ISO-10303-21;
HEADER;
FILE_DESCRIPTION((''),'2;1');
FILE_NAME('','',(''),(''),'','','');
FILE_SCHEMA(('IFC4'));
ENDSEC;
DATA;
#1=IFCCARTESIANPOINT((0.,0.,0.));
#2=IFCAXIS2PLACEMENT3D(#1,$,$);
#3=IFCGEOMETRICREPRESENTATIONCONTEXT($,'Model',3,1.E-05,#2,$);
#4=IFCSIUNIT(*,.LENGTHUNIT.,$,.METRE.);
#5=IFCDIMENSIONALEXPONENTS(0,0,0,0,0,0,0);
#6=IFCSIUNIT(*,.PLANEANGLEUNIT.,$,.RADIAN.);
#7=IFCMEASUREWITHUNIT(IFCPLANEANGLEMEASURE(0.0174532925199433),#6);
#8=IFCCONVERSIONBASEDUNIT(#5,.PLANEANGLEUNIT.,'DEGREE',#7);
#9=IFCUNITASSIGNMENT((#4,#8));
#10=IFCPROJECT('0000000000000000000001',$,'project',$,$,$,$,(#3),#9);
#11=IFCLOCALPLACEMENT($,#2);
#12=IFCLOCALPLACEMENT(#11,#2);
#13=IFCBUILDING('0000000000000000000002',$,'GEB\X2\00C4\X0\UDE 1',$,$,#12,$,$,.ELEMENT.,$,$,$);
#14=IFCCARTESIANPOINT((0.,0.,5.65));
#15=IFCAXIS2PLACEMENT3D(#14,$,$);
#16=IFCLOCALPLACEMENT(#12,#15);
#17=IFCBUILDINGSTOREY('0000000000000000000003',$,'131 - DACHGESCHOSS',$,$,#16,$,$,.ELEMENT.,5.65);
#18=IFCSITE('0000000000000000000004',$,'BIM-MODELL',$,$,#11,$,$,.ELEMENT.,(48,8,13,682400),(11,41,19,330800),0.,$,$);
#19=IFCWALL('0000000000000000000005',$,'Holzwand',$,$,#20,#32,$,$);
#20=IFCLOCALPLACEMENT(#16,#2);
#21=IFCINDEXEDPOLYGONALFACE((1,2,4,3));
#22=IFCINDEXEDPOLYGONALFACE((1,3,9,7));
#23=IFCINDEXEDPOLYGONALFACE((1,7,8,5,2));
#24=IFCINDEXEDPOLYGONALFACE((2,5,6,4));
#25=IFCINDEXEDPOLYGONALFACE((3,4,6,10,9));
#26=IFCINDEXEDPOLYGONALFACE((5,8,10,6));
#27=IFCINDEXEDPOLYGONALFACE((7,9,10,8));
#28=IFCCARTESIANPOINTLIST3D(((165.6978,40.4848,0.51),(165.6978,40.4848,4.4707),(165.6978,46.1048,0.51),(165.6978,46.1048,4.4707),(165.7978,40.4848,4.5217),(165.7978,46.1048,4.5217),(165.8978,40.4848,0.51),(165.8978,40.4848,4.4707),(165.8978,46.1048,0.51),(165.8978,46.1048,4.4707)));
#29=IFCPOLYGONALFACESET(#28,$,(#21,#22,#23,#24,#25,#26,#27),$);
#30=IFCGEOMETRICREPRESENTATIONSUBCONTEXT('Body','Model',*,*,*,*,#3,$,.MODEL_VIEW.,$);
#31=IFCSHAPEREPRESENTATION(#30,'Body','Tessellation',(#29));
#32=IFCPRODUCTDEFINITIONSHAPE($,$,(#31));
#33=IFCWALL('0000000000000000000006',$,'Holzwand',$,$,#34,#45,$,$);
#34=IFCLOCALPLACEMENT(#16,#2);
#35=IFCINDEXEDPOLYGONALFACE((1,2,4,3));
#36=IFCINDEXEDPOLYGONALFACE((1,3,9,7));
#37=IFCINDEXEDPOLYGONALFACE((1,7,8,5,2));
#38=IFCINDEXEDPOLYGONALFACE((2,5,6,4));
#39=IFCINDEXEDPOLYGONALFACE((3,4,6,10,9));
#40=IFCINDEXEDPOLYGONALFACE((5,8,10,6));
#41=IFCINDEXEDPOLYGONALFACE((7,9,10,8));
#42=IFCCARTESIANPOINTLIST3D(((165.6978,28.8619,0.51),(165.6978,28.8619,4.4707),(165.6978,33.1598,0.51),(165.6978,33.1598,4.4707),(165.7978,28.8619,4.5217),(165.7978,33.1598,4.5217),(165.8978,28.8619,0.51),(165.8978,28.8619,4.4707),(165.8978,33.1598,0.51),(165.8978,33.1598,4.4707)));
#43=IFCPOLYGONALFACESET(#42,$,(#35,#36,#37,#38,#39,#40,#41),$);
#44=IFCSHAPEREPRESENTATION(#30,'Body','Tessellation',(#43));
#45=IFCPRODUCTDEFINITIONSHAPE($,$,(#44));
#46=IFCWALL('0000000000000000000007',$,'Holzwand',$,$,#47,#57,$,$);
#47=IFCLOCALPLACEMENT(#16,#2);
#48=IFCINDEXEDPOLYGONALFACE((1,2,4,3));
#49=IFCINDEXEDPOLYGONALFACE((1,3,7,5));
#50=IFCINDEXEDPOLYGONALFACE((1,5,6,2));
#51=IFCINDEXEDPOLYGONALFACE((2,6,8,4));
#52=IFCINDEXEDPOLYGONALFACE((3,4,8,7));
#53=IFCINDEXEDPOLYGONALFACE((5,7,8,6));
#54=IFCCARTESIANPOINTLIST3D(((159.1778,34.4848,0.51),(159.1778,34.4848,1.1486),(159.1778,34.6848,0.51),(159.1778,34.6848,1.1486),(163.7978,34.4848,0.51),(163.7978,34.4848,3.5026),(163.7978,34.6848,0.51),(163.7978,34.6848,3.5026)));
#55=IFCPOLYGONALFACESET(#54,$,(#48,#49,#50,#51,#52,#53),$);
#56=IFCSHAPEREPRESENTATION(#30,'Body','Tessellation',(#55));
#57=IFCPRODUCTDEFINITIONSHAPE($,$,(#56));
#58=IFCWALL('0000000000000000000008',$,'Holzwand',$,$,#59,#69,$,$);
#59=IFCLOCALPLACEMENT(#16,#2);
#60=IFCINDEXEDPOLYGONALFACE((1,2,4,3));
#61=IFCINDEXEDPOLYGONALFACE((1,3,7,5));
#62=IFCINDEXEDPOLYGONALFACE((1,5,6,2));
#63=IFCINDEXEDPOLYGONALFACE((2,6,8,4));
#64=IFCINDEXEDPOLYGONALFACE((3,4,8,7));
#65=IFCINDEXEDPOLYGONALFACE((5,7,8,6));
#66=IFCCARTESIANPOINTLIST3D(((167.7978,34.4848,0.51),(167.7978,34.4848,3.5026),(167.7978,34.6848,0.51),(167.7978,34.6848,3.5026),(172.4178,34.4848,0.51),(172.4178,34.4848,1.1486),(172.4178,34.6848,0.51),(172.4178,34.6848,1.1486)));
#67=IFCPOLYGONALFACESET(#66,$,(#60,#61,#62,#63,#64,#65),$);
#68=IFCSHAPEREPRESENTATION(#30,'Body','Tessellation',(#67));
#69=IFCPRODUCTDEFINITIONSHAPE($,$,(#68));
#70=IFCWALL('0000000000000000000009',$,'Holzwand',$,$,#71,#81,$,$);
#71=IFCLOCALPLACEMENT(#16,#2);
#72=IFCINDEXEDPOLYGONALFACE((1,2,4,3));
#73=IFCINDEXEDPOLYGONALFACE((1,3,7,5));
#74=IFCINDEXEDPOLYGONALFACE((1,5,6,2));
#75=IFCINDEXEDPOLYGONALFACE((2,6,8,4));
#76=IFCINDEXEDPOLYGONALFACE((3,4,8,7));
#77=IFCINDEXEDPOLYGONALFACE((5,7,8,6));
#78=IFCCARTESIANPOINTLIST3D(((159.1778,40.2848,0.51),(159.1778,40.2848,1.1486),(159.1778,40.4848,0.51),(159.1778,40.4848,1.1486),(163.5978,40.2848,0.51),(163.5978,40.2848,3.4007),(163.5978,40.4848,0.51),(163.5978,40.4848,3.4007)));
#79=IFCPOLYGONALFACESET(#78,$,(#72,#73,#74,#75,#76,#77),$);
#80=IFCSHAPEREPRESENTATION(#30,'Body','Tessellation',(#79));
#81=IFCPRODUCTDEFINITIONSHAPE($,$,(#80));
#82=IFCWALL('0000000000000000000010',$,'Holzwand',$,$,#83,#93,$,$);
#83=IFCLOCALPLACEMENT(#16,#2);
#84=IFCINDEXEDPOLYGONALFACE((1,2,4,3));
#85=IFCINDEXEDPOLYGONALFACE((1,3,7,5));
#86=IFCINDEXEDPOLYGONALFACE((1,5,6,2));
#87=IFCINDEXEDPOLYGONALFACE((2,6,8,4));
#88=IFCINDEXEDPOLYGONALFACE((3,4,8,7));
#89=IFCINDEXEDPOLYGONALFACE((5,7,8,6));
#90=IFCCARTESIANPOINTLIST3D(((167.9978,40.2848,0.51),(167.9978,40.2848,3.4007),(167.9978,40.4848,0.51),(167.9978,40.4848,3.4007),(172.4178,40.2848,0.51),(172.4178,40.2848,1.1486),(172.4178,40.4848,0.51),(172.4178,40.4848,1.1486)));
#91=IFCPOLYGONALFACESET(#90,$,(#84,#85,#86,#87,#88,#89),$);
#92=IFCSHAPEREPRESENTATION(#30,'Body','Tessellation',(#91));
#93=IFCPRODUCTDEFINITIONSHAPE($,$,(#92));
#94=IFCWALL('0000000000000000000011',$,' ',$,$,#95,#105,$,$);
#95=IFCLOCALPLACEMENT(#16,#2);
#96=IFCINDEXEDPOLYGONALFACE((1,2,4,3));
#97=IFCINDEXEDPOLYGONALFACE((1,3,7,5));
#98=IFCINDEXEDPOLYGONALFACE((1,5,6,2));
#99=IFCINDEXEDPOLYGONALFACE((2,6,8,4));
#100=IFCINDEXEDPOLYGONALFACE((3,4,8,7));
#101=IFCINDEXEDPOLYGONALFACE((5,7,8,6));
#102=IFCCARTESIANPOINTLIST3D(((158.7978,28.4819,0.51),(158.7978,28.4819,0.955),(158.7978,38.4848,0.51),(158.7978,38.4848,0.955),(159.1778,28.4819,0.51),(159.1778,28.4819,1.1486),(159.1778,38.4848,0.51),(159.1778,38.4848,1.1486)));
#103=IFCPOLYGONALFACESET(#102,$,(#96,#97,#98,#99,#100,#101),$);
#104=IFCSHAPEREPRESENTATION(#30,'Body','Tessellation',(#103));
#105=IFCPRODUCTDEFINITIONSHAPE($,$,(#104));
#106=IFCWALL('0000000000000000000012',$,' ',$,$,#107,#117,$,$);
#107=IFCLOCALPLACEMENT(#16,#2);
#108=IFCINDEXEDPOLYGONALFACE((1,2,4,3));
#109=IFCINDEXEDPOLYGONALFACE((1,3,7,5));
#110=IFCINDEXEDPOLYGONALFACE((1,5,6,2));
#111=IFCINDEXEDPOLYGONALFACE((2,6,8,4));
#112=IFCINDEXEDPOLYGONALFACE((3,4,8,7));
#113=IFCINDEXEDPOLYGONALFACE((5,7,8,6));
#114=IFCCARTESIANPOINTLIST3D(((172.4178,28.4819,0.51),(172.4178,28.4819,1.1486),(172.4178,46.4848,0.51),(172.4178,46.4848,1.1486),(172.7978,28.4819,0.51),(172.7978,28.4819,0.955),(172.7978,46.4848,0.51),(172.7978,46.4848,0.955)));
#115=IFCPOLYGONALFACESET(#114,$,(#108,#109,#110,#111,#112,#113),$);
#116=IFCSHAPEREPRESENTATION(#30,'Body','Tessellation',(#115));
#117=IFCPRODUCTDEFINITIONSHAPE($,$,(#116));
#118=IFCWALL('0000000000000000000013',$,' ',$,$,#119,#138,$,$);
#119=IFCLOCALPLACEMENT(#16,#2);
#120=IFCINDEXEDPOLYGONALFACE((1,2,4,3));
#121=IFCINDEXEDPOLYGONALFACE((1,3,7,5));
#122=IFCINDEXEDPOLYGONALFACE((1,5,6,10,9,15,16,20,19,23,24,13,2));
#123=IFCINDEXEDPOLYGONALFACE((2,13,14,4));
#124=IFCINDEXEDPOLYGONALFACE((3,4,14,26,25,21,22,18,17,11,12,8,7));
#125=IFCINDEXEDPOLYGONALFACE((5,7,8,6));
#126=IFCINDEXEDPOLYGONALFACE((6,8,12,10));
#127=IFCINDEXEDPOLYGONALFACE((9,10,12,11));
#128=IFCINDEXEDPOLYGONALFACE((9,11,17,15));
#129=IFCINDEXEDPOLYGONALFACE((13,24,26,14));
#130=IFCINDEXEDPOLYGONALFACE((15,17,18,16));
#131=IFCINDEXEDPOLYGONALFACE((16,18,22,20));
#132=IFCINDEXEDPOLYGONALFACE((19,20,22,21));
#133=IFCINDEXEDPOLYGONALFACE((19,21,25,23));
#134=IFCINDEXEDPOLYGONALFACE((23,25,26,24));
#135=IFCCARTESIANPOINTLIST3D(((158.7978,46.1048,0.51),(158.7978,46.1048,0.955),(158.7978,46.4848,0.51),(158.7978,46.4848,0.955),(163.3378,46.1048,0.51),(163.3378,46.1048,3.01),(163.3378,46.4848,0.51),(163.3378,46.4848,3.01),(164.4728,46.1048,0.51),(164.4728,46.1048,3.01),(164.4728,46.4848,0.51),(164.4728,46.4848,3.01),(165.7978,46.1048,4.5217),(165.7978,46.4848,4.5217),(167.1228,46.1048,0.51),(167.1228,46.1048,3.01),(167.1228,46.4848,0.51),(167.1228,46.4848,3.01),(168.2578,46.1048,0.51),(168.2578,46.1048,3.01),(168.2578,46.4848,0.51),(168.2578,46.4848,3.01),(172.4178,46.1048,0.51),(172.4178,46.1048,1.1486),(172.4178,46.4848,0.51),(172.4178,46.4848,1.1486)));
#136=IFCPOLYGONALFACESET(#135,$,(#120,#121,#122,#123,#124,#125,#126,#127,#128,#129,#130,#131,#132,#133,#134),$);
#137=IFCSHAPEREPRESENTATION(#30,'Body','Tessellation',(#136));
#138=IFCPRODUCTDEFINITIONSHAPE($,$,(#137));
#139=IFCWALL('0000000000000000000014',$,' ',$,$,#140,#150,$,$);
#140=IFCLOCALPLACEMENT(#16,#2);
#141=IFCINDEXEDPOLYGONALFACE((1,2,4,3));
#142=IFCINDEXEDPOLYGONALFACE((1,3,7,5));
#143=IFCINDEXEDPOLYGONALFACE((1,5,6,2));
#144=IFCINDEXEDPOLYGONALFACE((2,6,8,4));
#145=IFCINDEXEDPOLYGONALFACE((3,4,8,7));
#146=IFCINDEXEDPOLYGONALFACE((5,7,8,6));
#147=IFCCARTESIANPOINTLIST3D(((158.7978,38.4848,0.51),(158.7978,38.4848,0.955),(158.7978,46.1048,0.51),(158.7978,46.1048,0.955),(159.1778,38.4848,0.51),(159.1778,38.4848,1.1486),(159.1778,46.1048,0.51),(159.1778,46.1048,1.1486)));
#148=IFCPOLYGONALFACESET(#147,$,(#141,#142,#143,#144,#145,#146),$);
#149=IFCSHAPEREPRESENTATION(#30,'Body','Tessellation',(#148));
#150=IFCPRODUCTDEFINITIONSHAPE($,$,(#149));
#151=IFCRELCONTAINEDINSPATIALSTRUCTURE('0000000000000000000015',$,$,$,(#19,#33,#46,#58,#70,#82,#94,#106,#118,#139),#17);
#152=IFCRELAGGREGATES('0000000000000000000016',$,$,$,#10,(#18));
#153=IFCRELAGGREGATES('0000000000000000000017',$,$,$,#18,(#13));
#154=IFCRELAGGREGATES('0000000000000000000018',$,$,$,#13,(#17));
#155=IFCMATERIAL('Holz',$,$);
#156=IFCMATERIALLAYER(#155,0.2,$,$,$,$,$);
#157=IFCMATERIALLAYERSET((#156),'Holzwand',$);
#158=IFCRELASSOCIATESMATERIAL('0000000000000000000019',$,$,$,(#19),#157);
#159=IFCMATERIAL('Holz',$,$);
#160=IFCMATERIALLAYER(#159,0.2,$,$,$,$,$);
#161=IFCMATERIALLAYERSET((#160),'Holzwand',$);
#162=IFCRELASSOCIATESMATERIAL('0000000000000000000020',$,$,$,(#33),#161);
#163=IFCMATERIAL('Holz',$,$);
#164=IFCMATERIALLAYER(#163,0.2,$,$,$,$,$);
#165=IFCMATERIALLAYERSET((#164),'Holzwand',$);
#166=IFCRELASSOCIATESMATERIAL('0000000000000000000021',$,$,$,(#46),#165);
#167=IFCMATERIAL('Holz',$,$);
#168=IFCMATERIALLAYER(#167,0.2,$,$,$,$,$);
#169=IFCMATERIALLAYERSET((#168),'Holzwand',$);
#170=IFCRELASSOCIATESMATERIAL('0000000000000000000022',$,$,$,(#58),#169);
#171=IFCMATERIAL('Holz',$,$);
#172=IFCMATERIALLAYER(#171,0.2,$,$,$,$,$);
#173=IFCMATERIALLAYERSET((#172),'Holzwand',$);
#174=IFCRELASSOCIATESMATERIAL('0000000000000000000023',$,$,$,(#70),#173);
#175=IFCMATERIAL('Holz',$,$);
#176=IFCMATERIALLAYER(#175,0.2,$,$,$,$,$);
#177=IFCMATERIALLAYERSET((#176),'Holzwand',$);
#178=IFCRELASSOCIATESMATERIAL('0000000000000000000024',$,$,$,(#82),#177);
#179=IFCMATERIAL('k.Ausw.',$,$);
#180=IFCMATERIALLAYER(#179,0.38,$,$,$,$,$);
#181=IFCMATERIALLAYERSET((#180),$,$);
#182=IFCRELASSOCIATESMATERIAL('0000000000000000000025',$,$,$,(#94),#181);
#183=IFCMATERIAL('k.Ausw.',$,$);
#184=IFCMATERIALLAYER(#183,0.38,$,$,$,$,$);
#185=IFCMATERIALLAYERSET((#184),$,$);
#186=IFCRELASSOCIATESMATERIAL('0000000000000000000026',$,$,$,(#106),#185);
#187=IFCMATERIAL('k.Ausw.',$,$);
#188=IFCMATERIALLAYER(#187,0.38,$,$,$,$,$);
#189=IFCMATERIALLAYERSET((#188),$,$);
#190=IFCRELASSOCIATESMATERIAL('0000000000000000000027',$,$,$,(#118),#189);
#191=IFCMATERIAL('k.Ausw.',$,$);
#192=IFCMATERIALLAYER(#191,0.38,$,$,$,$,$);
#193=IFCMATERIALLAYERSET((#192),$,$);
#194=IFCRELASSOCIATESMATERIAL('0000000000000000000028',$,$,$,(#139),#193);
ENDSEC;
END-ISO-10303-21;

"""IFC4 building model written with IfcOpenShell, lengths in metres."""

from ifc_helpers import new_model, entity, si_unit, converted_unit, frame, frame_2d, origin, origin_with_axes, place, context, subcontext, project, spatial, polyline, rectangle, outline, extrude, clip, halfspace, bounded_halfspace, material, layer, layer_set, layer_usage, element, save


model = new_model("IFC4")

# Units and contexts
model_context = context("Model", 3, precision=1e-05, world=origin())
body_context = subcontext(model_context, "Body", "Model", "MODEL_VIEW")
ifc_project = project(units=[si_unit("LENGTHUNIT", "METRE"), converted_unit("PLANEANGLEUNIT", "DEGREE", entity("IfcPlaneAngleMeasure", 0.0174532925199433), si_unit("PLANEANGLEUNIT", "RADIAN"), dimensions=[0, 0, 0, 0, 0, 0, 0])], contexts=[model_context])

# Site, building, storey
site_placement = place(None, origin())
site = spatial("IfcSite", under=ifc_project, at=site_placement, Name="BIM-MODELL", CompositionType="ELEMENT", RefLatitude=(48, 8, 13, 682400), RefLongitude=(11, 41, 19, 330800), RefElevation=0.0)
building_placement = place(site_placement, origin())
building = spatial("IfcBuilding", under=site, at=building_placement, Name="GEBÄUDE 1", CompositionType="ELEMENT")
storey_placement = place(building_placement, frame((0.0, 0.0, 5.65)))
storey = spatial("IfcBuildingStorey", under=building, at=storey_placement, Name="131 - DACHGESCHOSS", CompositionType="ELEMENT", Elevation=5.65)

# Walls
ifc_material_1 = material(Name="Holz")
ifc_layer_1 = layer(ifc_material_1, 0.2)
ifc_layer_set_1 = layer_set([ifc_layer_1], Name="Holzwand")
ifc_layer_usage_1 = layer_usage(ifc_layer_set_1, "AXIS2", "POSITIVE", 0.0)
wall_1_placement = place(storey_placement, frame((165.6978, 46.1048, 0.51), z_axis=(0.0, 0.0, 1.0), x_axis=(0.0, -1.0, 0.0)))
element("IfcWall", 1, at=wall_1_placement, inside=storey, material=ifc_layer_usage_1, Name="Holzwand", context=body_context, shape_type="Clipping", body=[
    clip(clip(extrude(rectangle(XDim=5.62, YDim=0.2, at=frame_2d((2.81, 0.1), x_axis=(1.0, 0.0))), origin_with_axes(), (0.0, 0.0, 1.0), 4.0117), bounded_halfspace(frame((2.81, 0.05, 3.9862), z_axis=(0.0, 0.45399, -0.891007), x_axis=(0.0, 0.891007, 0.45399)), True, origin_with_axes(), polyline([(5.62, 0.0), (5.62, 0.1), (0.0, 0.1), (0.0, 0.0), (5.62, 0.0)]))), bounded_halfspace(frame((2.81, 0.15, 3.9862), z_axis=(0.0, -0.45399, -0.891007), x_axis=(0.0, -0.891007, 0.45399)), True, origin_with_axes(), polyline([(0.0, 0.2), (0.0, 0.1), (5.62, 0.1), (5.62, 0.2), (0.0, 0.2)]))),
])
ifc_material_2 = material(Name="Holz")
ifc_layer_2 = layer(ifc_material_2, 0.2)
ifc_layer_set_2 = layer_set([ifc_layer_2], Name="Holzwand")
ifc_layer_usage_2 = layer_usage(ifc_layer_set_2, "AXIS2", "POSITIVE", 0.0)
wall_2_placement = place(storey_placement, frame((165.6978, 33.1598, 0.51), z_axis=(0.0, 0.0, 1.0), x_axis=(0.0, -1.0, 0.0)))
element("IfcWall", 2, at=wall_2_placement, inside=storey, material=ifc_layer_usage_2, Name="Holzwand", context=body_context, shape_type="Clipping", body=[
    clip(clip(extrude(rectangle(XDim=4.2979, YDim=0.2, at=frame_2d((2.1489, 0.1), x_axis=(1.0, 0.0))), origin_with_axes(), (0.0, 0.0, 1.0), 4.0117), bounded_halfspace(frame((2.1489, 0.05, 3.9862), z_axis=(0.0, 0.45399, -0.891007), x_axis=(0.0, 0.891007, 0.45399)), True, origin_with_axes(), polyline([(4.2979, 0.0), (4.2979, 0.1), (0.0, 0.1), (0.0, 0.0), (4.2979, 0.0)]))), bounded_halfspace(frame((2.1489, 0.15, 3.9862), z_axis=(0.0, -0.45399, -0.891007), x_axis=(0.0, -0.891007, 0.45399)), True, origin_with_axes(), polyline([(0.0, 0.2), (0.0, 0.1), (4.2979, 0.1), (4.2979, 0.2), (0.0, 0.2)]))),
])
ifc_material_3 = material(Name="Holz")
ifc_layer_3 = layer(ifc_material_3, 0.2)
ifc_layer_set_3 = layer_set([ifc_layer_3], Name="Holzwand")
ifc_layer_usage_3 = layer_usage(ifc_layer_set_3, "AXIS2", "POSITIVE", 0.0)
wall_3_placement = place(storey_placement, frame((159.1778, 34.4848, 0.51)))
element("IfcWall", 3, at=wall_3_placement, inside=storey, material=ifc_layer_usage_3, Name="Holzwand", context=body_context, shape_type="Clipping", body=[
    clip(extrude(rectangle(XDim=4.62, YDim=0.2, at=frame_2d((2.31, 0.1), x_axis=(1.0, 0.0))), origin_with_axes(), (0.0, 0.0, 1.0), 2.9926), halfspace(frame((2.31, 0.1, 1.8156), z_axis=(0.45399, 0.0, -0.891007), x_axis=(0.891007, 0.0, 0.45399)), True)),
])
ifc_material_4 = material(Name="Holz")
ifc_layer_4 = layer(ifc_material_4, 0.2)
ifc_layer_set_4 = layer_set([ifc_layer_4], Name="Holzwand")
ifc_layer_usage_4 = layer_usage(ifc_layer_set_4, "AXIS2", "POSITIVE", 0.0)
wall_4_placement = place(storey_placement, frame((167.7978, 34.4848, 0.51)))
element("IfcWall", 4, at=wall_4_placement, inside=storey, material=ifc_layer_usage_4, Name="Holzwand", context=body_context, shape_type="Clipping", body=[
    clip(extrude(rectangle(XDim=4.62, YDim=0.2, at=frame_2d((2.31, 0.1), x_axis=(1.0, 0.0))), origin_with_axes(), (0.0, 0.0, 1.0), 2.9926), halfspace(frame((2.31, 0.1, 1.8156), z_axis=(-0.45399, 0.0, -0.891007), x_axis=(0.891007, 0.0, -0.45399)), True)),
])
ifc_material_5 = material(Name="Holz")
ifc_layer_5 = layer(ifc_material_5, 0.2)
ifc_layer_set_5 = layer_set([ifc_layer_5], Name="Holzwand")
ifc_layer_usage_5 = layer_usage(ifc_layer_set_5, "AXIS2", "POSITIVE", 0.0)
wall_5_placement = place(storey_placement, frame((163.5978, 40.4848, 0.51), z_axis=(0.0, 0.0, 1.0), x_axis=(-1.0, 0.0, 0.0)))
element("IfcWall", 5, at=wall_5_placement, inside=storey, material=ifc_layer_usage_5, Name="Holzwand", context=body_context, shape_type="Clipping", body=[
    clip(extrude(rectangle(XDim=4.42, YDim=0.2, at=frame_2d((2.21, 0.1), x_axis=(1.0, 0.0))), origin_with_axes(), (0.0, 0.0, 1.0), 2.8907), halfspace(frame((2.21, 0.1, 1.7647), z_axis=(-0.45399, 0.0, -0.891007), x_axis=(0.891007, 0.0, -0.45399)), True)),
])
ifc_material_6 = material(Name="Holz")
ifc_layer_6 = layer(ifc_material_6, 0.2)
ifc_layer_set_6 = layer_set([ifc_layer_6], Name="Holzwand")
ifc_layer_usage_6 = layer_usage(ifc_layer_set_6, "AXIS2", "POSITIVE", 0.0)
wall_6_placement = place(storey_placement, frame((172.4178, 40.4848, 0.51), z_axis=(0.0, 0.0, 1.0), x_axis=(-1.0, 0.0, 0.0)))
element("IfcWall", 6, at=wall_6_placement, inside=storey, material=ifc_layer_usage_6, Name="Holzwand", context=body_context, shape_type="Clipping", body=[
    clip(extrude(rectangle(XDim=4.42, YDim=0.2, at=frame_2d((2.21, 0.1), x_axis=(1.0, 0.0))), origin_with_axes(), (0.0, 0.0, 1.0), 2.8907), halfspace(frame((2.21, 0.1, 1.7647), z_axis=(0.45399, 0.0, -0.891007), x_axis=(0.891007, 0.0, 0.45399)), True)),
])
ifc_material_7 = material(Name="k.Ausw.")
ifc_layer_7 = layer(ifc_material_7, 0.38)
ifc_layer_set_7 = layer_set([ifc_layer_7])
ifc_layer_usage_7 = layer_usage(ifc_layer_set_7, "AXIS2", "POSITIVE", 0.0)
wall_7_placement = place(storey_placement, frame((158.7978, 38.4848, 0.51), z_axis=(0.0, 0.0, 1.0), x_axis=(0.0, -1.0, 0.0)))
element("IfcWall", 7, at=wall_7_placement, inside=storey, material=ifc_layer_usage_7, Name=" ", context=body_context, shape_type="Clipping", body=[
    clip(extrude(rectangle(XDim=10.0029, YDim=0.38, at=frame_2d((5.0014, 0.19), x_axis=(1.0, 0.0))), origin_with_axes(), (0.0, 0.0, 1.0), 0.6386), halfspace(frame((5.0014, 0.19, 0.5418), z_axis=(0.0, 0.45399, -0.891007), x_axis=(0.0, -0.891007, -0.45399)), True)),
])
ifc_material_8 = material(Name="k.Ausw.")
ifc_layer_8 = layer(ifc_material_8, 0.38)
ifc_layer_set_8 = layer_set([ifc_layer_8])
ifc_layer_usage_8 = layer_usage(ifc_layer_set_8, "AXIS2", "POSITIVE", 0.0)
wall_8_placement = place(storey_placement, frame((172.7978, 28.4819, 0.51), z_axis=(0.0, 0.0, 1.0), x_axis=(0.0, 1.0, 0.0)))
element("IfcWall", 8, at=wall_8_placement, inside=storey, material=ifc_layer_usage_8, Name=" ", context=body_context, shape_type="Clipping", body=[
    clip(extrude(rectangle(XDim=18.0029, YDim=0.38, at=frame_2d((9.0014, 0.19), x_axis=(1.0, 0.0))), origin_with_axes(), (0.0, 0.0, 1.0), 0.6386), halfspace(frame((9.0014, 0.19, 0.5418), z_axis=(0.0, 0.45399, -0.891007), x_axis=(0.0, -0.891007, -0.45399)), True)),
])

# Wall, openings
ifc_material_9 = material(Name="k.Ausw.")
ifc_layer_9 = layer(ifc_material_9, 0.38)
ifc_layer_set_9 = layer_set([ifc_layer_9])
ifc_layer_usage_9 = layer_usage(ifc_layer_set_9, "AXIS2", "POSITIVE", 0.0)
wall_9_placement = place(storey_placement, frame((172.4178, 46.4848, 0.51), z_axis=(0.0, 0.0, 1.0), x_axis=(-1.0, 0.0, 0.0)))
wall_9 = element("IfcWall", 9, at=wall_9_placement, inside=storey, material=ifc_layer_usage_9, Name=" ", context=body_context, shape_type="Clipping", body=[
    clip(clip(extrude(rectangle(XDim=13.62, YDim=0.38, at=frame_2d((6.81, 0.19), x_axis=(1.0, 0.0))), origin_with_axes(), (0.0, 0.0, 1.0), 4.0117), bounded_halfspace(frame((10.12, 0.19, 2.2283), z_axis=(-0.45399, 0.0, -0.891007), x_axis=(0.0, -1.0, 0.0)), True, origin_with_axes(), polyline([(6.62, 0.38), (6.62, 0.0), (13.62, 0.0), (13.62, 0.38), (6.62, 0.38)]))), bounded_halfspace(frame((3.31, 0.19, 2.3251), z_axis=(0.45399, 0.0, -0.891007), x_axis=(0.0, -1.0, 0.0)), True, origin_with_axes(), polyline([(0.0, 0.38), (0.0, 0.0), (6.62, 0.0), (6.62, 0.38), (0.0, 0.38)]))),
])
opening_1_placement = place(wall_9_placement, frame((5.295, 0.38, 0.0), z_axis=(0.0, -1.0, 0.0), x_axis=(0.0, 0.0, 1.0)))
element("IfcOpeningElement", 10, at=opening_1_placement, cuts=wall_9, ObjectType="Opening", context=body_context, shape_type="SweptSolid", body=[
    extrude(outline(polyline([(0.0, 1.135), (2.5, 1.135), (2.5, 0.0), (0.0, 0.0), (0.0, 1.135)])), origin_with_axes(), (0.0, 0.0, 1.0), 0.38),
])
opening_2_placement = place(wall_9_placement, frame((9.08, 0.38, 0.0), z_axis=(0.0, -1.0, 0.0), x_axis=(0.0, 0.0, 1.0)))
element("IfcOpeningElement", 11, at=opening_2_placement, cuts=wall_9, ObjectType="Opening", context=body_context, shape_type="SweptSolid", body=[
    extrude(outline(polyline([(0.0, 1.135), (2.5, 1.135), (2.5, 0.0), (0.0, 0.0), (0.0, 1.135)])), origin_with_axes(), (0.0, 0.0, 1.0), 0.38),
])

# Wall
ifc_material_10 = material(Name="k.Ausw.")
ifc_layer_10 = layer(ifc_material_10, 0.38)
ifc_layer_set_10 = layer_set([ifc_layer_10])
ifc_layer_usage_10 = layer_usage(ifc_layer_set_10, "AXIS2", "POSITIVE", 0.0)
wall_10_placement = place(storey_placement, frame((158.7978, 46.1048, 0.51), z_axis=(0.0, 0.0, 1.0), x_axis=(0.0, -1.0, 0.0)))
element("IfcWall", 12, at=wall_10_placement, inside=storey, material=ifc_layer_usage_10, Name=" ", context=body_context, shape_type="Clipping", body=[
    clip(extrude(rectangle(XDim=7.62, YDim=0.38, at=frame_2d((3.81, 0.19), x_axis=(1.0, 0.0))), origin_with_axes(), (0.0, 0.0, 1.0), 0.6386), halfspace(frame((3.81, 0.19, 0.5418), z_axis=(0.0, 0.45399, -0.891007), x_axis=(0.0, -0.891007, -0.45399)), True)),
])

save(model, "model.ifc")
